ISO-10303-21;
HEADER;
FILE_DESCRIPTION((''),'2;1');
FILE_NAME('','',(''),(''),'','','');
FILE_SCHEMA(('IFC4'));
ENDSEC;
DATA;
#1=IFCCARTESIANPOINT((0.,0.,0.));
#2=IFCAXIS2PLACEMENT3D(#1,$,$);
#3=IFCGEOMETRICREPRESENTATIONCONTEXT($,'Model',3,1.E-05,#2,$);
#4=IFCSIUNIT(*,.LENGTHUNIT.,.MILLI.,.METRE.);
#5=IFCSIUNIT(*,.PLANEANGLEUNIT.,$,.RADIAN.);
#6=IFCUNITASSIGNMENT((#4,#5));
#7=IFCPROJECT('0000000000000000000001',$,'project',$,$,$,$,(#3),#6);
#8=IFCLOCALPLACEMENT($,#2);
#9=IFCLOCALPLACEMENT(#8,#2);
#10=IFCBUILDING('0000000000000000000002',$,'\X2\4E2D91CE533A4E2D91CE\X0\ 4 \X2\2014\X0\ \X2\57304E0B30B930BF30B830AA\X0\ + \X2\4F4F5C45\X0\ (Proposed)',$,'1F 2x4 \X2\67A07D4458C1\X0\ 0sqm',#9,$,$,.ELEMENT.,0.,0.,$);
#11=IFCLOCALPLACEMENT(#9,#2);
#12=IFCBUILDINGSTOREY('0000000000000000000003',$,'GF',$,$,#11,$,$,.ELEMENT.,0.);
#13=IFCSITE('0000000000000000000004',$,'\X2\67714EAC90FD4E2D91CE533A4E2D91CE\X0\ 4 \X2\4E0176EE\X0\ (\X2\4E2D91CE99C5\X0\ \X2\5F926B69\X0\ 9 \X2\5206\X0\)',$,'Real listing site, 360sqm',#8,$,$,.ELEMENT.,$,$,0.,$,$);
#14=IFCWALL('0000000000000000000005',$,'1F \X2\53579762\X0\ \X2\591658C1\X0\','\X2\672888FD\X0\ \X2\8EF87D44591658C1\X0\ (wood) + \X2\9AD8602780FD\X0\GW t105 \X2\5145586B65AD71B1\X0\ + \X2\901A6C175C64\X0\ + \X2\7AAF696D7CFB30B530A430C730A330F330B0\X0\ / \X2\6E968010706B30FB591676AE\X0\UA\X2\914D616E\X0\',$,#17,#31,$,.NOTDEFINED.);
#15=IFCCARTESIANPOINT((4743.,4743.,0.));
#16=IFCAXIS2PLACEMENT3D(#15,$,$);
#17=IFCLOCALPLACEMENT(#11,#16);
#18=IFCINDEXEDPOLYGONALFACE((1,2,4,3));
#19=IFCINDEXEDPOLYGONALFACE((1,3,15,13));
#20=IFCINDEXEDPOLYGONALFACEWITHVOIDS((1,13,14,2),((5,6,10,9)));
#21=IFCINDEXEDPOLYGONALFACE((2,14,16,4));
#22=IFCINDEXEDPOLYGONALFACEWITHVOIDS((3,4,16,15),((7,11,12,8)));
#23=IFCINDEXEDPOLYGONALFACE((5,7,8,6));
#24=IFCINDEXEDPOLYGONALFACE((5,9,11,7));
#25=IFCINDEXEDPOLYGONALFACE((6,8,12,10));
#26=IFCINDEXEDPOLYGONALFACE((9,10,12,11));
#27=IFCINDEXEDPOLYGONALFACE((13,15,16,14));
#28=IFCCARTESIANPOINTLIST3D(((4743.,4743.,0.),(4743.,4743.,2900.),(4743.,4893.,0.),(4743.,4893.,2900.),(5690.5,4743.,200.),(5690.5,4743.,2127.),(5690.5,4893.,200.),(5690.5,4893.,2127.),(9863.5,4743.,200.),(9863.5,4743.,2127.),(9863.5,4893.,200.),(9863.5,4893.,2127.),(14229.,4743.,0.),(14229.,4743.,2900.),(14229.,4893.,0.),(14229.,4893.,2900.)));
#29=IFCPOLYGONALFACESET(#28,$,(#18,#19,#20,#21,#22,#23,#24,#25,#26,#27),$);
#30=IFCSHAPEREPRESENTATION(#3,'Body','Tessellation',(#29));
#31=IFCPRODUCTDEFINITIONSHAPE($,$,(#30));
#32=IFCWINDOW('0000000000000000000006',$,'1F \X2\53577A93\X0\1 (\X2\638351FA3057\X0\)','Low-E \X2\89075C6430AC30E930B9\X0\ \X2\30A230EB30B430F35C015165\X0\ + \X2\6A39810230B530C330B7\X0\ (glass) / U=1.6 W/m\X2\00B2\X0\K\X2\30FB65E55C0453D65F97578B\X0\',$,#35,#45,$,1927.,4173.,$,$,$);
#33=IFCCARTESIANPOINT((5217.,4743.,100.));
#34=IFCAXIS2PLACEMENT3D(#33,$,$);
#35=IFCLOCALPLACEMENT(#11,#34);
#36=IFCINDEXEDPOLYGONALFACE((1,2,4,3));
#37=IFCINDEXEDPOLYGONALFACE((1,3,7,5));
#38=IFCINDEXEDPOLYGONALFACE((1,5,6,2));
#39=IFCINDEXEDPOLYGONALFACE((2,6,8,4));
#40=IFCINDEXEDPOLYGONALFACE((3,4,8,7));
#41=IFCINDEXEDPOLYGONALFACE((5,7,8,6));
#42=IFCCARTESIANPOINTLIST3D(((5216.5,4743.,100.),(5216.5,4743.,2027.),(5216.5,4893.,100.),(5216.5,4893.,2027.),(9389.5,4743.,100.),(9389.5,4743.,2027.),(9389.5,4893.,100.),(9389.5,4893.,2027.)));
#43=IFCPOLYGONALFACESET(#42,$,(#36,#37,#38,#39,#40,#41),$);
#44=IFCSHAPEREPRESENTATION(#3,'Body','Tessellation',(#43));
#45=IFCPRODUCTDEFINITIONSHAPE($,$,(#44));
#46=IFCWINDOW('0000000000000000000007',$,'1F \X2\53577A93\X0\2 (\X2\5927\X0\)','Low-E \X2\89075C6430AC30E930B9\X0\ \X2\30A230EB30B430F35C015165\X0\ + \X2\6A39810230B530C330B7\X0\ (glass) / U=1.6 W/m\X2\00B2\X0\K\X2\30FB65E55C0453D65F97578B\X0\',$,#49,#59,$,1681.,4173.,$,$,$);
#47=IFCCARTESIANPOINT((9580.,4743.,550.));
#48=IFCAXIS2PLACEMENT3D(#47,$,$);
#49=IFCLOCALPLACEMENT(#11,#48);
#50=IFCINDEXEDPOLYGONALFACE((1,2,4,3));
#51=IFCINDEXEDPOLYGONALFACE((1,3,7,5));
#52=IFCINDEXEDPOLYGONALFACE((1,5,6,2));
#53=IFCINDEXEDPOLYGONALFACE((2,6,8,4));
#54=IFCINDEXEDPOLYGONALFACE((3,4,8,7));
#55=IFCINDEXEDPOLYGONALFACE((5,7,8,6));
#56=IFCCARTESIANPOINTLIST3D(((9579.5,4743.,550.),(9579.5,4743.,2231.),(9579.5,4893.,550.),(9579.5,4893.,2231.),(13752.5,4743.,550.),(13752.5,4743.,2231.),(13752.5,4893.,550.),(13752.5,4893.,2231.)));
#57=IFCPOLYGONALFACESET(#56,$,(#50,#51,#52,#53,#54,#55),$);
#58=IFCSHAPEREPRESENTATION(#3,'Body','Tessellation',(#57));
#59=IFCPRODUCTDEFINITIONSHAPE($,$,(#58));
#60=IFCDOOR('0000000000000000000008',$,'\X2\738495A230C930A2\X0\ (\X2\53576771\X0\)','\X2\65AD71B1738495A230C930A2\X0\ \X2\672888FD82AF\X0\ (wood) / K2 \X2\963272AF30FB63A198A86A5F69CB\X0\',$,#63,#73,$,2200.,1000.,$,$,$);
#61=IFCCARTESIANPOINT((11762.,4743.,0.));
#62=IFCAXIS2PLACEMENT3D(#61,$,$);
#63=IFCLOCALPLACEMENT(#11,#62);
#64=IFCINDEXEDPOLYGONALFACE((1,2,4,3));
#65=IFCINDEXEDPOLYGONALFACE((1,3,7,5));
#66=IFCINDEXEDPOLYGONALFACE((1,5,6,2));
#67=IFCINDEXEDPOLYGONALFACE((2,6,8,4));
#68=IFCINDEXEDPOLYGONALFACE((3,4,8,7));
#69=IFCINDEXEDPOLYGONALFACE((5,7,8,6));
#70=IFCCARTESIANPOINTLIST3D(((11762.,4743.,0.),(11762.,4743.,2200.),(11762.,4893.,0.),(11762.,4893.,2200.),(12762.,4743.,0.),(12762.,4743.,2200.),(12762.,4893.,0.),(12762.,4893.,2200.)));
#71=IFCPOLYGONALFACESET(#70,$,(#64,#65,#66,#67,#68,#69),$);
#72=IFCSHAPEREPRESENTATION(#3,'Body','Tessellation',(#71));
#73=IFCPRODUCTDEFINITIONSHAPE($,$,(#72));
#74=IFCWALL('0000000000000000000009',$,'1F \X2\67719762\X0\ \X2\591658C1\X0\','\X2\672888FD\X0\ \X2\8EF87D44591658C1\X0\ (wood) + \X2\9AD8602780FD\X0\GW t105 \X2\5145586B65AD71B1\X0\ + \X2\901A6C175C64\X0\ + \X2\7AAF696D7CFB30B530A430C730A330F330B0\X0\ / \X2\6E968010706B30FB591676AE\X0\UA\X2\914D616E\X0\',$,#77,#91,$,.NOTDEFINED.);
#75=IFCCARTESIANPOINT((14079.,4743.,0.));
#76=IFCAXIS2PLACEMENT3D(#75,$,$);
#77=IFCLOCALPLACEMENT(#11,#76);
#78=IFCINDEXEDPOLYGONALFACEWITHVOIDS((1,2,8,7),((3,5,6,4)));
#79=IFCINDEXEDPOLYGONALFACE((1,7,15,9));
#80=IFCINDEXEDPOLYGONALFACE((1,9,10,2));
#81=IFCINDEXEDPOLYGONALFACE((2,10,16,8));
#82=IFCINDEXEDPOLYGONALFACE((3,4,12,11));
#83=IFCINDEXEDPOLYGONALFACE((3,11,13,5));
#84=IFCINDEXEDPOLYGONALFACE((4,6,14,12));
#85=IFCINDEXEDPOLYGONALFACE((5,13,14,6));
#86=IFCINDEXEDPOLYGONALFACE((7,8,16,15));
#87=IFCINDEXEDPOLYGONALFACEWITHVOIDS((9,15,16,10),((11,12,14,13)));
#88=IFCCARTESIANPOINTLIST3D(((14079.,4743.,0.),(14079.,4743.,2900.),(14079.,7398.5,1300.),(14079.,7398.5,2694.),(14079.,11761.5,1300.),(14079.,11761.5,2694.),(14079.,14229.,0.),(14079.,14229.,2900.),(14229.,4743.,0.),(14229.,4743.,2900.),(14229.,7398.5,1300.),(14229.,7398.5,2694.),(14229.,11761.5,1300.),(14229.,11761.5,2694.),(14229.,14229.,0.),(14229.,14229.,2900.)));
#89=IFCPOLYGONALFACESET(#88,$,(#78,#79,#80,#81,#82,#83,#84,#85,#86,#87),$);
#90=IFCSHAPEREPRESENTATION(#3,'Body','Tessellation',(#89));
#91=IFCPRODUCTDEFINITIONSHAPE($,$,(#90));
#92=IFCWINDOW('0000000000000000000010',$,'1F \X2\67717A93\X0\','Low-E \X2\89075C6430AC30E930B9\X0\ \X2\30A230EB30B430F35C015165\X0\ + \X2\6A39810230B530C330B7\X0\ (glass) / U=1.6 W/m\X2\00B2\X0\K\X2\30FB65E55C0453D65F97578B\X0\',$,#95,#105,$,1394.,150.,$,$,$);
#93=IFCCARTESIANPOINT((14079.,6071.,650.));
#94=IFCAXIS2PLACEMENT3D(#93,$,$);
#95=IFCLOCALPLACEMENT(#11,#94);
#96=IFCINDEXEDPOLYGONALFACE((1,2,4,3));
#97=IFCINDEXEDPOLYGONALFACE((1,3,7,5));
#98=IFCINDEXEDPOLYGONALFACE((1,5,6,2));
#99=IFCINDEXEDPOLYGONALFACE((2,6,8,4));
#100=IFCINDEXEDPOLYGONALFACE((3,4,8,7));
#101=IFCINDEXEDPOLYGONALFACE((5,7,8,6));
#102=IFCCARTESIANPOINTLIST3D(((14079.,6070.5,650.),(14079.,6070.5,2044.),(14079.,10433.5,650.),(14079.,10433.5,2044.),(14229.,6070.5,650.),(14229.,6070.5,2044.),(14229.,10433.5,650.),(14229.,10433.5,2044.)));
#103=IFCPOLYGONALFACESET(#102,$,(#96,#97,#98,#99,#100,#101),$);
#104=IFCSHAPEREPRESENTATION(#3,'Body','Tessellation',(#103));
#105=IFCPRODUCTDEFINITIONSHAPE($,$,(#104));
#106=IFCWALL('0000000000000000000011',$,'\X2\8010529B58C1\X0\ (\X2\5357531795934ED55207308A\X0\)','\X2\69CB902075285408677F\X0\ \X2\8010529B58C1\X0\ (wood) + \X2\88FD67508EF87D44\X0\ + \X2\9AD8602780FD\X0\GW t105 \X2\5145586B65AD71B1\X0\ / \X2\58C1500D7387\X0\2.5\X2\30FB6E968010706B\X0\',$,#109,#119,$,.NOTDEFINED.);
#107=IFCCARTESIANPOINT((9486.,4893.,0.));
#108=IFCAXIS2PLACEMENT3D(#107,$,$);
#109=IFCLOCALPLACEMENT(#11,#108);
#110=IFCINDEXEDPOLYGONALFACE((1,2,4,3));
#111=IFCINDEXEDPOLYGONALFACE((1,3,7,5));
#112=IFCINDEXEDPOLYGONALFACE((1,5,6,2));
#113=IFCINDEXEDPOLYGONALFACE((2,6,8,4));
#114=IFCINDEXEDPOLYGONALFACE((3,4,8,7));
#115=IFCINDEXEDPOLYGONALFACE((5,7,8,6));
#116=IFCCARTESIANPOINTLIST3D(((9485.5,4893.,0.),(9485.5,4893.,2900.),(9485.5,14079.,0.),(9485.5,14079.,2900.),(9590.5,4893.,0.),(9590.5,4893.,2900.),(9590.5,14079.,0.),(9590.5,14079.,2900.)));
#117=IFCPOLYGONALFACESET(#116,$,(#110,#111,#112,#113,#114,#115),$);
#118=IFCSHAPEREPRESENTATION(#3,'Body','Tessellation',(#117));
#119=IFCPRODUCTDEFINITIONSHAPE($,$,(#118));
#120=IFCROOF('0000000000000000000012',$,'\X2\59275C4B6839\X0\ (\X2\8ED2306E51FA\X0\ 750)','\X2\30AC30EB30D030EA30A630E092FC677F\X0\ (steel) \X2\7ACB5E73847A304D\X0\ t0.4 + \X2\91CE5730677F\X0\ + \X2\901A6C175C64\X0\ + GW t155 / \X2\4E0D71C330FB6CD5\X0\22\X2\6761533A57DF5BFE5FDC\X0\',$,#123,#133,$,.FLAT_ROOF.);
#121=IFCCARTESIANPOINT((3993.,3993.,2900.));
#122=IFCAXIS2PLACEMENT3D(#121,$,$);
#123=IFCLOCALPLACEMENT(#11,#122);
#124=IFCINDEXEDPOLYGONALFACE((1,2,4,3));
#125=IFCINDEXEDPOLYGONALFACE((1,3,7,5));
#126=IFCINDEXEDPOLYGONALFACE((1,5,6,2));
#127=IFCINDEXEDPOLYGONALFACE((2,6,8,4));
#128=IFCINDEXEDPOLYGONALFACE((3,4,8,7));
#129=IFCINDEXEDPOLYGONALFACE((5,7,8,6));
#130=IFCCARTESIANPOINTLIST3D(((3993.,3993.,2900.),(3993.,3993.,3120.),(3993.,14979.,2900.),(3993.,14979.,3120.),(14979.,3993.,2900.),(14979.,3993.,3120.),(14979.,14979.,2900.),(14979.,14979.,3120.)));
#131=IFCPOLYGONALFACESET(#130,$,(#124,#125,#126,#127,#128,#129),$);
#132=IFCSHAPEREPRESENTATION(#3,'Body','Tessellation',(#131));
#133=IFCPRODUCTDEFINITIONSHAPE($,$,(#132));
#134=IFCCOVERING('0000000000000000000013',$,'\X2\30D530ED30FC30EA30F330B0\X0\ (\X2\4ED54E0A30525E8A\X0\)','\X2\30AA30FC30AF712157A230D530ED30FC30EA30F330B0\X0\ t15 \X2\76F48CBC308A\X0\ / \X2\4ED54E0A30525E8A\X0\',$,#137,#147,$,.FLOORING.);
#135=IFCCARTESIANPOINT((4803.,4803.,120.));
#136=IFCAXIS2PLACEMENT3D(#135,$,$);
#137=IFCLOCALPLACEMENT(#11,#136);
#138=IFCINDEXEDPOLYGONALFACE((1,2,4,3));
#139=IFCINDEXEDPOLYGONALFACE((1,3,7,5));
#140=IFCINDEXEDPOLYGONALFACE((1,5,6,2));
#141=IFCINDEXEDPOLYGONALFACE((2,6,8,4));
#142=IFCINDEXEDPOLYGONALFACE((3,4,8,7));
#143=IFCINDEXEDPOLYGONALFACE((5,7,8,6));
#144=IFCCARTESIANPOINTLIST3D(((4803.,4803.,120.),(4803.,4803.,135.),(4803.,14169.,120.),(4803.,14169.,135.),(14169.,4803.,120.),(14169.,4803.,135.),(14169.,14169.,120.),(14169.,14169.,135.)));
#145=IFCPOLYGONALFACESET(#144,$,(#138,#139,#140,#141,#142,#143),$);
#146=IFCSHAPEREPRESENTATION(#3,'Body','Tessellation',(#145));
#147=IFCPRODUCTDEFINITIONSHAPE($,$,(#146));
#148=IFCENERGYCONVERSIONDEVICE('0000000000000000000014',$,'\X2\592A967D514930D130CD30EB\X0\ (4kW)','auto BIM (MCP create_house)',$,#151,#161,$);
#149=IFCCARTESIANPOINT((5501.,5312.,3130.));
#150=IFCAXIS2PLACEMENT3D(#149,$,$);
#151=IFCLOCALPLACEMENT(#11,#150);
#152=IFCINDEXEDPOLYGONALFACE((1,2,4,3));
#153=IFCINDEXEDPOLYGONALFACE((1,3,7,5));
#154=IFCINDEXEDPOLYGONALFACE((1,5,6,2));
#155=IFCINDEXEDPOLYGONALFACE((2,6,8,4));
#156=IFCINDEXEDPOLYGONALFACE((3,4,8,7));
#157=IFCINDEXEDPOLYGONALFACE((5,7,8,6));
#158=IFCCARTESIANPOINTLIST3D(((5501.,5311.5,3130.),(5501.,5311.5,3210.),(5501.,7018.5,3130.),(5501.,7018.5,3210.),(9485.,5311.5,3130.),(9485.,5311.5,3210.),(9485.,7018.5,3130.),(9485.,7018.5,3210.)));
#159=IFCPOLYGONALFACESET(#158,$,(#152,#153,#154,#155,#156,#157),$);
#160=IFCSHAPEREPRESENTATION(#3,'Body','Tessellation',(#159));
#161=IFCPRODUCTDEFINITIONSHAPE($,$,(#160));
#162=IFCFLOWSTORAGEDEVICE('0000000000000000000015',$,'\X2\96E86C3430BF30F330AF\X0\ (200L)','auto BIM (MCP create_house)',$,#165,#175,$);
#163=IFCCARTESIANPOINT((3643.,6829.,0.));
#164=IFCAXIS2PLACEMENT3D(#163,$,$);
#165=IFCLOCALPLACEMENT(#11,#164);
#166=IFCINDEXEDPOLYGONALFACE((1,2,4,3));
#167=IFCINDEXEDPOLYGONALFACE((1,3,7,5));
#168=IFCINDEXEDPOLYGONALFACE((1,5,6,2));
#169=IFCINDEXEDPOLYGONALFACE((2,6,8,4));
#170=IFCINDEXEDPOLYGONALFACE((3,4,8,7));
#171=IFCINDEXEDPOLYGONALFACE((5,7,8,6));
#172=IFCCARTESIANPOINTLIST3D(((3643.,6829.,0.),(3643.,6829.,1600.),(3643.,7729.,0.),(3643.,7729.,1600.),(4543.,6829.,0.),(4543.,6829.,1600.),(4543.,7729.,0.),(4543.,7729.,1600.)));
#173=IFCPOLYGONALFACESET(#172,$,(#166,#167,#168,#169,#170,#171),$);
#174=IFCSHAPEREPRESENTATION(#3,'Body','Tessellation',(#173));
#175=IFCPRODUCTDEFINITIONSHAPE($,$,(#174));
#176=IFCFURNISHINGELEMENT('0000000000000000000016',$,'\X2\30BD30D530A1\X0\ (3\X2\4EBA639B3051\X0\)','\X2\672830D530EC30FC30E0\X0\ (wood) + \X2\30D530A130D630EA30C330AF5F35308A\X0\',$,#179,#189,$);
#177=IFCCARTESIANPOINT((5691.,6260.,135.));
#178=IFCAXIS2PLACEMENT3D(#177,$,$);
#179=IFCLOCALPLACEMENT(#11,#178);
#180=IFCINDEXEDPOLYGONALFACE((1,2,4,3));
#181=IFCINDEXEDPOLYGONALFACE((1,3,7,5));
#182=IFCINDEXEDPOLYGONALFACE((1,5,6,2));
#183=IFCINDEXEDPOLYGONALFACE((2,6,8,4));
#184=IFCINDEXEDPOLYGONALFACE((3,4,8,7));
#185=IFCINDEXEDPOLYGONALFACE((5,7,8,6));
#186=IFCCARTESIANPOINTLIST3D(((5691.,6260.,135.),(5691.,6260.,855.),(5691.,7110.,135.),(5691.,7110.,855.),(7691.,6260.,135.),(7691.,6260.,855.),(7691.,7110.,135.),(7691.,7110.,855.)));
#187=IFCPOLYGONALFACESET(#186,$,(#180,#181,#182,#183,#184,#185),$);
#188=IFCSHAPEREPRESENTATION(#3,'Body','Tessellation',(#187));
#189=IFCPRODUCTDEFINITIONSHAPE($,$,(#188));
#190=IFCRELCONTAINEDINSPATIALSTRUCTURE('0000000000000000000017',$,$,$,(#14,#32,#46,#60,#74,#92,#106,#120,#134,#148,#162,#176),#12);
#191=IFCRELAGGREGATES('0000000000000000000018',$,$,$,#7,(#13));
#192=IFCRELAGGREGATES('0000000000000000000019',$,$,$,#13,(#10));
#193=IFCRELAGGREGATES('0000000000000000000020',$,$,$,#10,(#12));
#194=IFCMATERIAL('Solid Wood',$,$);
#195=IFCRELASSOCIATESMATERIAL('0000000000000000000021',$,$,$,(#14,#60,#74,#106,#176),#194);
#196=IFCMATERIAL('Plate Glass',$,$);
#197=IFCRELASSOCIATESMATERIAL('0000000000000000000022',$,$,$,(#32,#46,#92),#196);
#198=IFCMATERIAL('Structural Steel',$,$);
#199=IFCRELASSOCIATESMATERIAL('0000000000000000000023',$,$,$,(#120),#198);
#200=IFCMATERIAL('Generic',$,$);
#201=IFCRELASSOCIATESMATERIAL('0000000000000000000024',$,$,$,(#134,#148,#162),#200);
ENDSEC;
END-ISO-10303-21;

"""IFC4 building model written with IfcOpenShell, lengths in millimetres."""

from ifc_helpers import new_model, si_unit, frame, frame_2d, origin, place, context, project, spatial, rectangle, extrude, material, element, fill, save


model = new_model("IFC4")

# Units and contexts
model_context = context("Model", 3, precision=1e-05, world=origin())
ifc_project = project(units=[si_unit("LENGTHUNIT", "METRE", prefix="MILLI"), si_unit("PLANEANGLEUNIT", "RADIAN")], contexts=[model_context])

# Site, building, storey
site_placement = place(None, origin())
site = spatial("IfcSite", under=ifc_project, at=site_placement, Name="東京都中野区中野 4 丁目 (中野駅 徒歩 9 分)", ObjectType="Real listing site, 360sqm", CompositionType="ELEMENT", RefElevation=0.0)
building_placement = place(site_placement, origin())
building = spatial("IfcBuilding", under=site, at=building_placement, Name="中野区中野 4 — 地下スタジオ + 住居 (Proposed)", ObjectType="1F 2x4 枠組壁 0sqm", CompositionType="ELEMENT", ElevationOfRefHeight=0.0, ElevationOfTerrain=0.0)
storey_placement = place(building_placement, origin())
storey = spatial("IfcBuildingStorey", under=building, at=storey_placement, Name="GF", CompositionType="ELEMENT", Elevation=0.0)

# Shared definitions
ifc_material_1 = material(Name="Solid Wood")

# Wall, openings, windows, door
wall_1_placement = place(storey_placement, frame((4743.0, 4743.0, 0.0)))
wall_1 = element("IfcWall", 1, at=wall_1_placement, inside=storey, material=ifc_material_1, Name="1F 南面 外壁", Description="木製 軸組外壁 (wood) + 高性能GW t105 充填断熱 + 通気層 + 窯業系サイディング / 準耐火・外皮UA配慮", PredefinedType="NOTDEFINED", context=model_context, shape_type="SweptSolid", body=[
    extrude(rectangle(XDim=9486.0, YDim=150.0, at=frame_2d((4743.0, 75.0))), frame((4743.0, 4743.0, 0.0)), (0.0, 0.0, 1.0), 2900.0),
])
opening_1_placement = place(storey_placement, frame((5217.0, 4743.0, 100.0)))
opening_1 = element("IfcOpeningElement", 2, at=opening_1_placement, cuts=wall_1, PredefinedType="NOTDEFINED", context=model_context, shape_type="SweptSolid", body=[
    extrude(rectangle(XDim=4173.0, YDim=150.0, at=frame_2d((2086.0, 75.0))), frame((5217.0, 4743.0, 100.0)), (0.0, 0.0, 1.0), 1927.0),
])
opening_2_placement = place(storey_placement, frame((9580.0, 4743.0, 550.0)))
opening_2 = element("IfcOpeningElement", 3, at=opening_2_placement, cuts=wall_1, PredefinedType="NOTDEFINED", context=model_context, shape_type="SweptSolid", body=[
    extrude(rectangle(XDim=4173.0, YDim=150.0, at=frame_2d((2086.0, 75.0))), frame((9580.0, 4743.0, 550.0)), (0.0, 0.0, 1.0), 1681.0),
])
opening_3_placement = place(storey_placement, frame((11762.0, 4743.0, 0.0)))
opening_3 = element("IfcOpeningElement", 4, at=opening_3_placement, cuts=wall_1, PredefinedType="NOTDEFINED", context=model_context, shape_type="SweptSolid", body=[
    extrude(rectangle(XDim=1000.0, YDim=150.0, at=frame_2d((500.0, 75.0))), frame((11762.0, 4743.0, 0.0)), (0.0, 0.0, 1.0), 2200.0),
])
ifc_material_2 = material(Name="Plate Glass")
window_1_placement = place(storey_placement, frame((5217.0, 4743.0, 100.0)))
window_1 = element("IfcWindow", 5, at=window_1_placement, inside=storey, material=ifc_material_2, Name="1F 南窓1 (掃出し)", Description="Low-E 複層ガラス アルゴン封入 + 樹脂サッシ (glass) / U=1.6 W/m²K・日射取得型", OverallHeight=1927.0, OverallWidth=4173.0, context=model_context, shape_type="SweptSolid", body=[
    extrude(rectangle(XDim=4173.0, YDim=150.0, at=frame_2d((2086.0, 75.0))), frame((5217.0, 4743.0, 100.0)), (0.0, 0.0, 1.0), 1927.0),
])
fill(opening_1, window_1)
window_2_placement = place(storey_placement, frame((9580.0, 4743.0, 550.0)))
window_2 = element("IfcWindow", 6, at=window_2_placement, inside=storey, material=ifc_material_2, Name="1F 南窓2 (大)", Description="Low-E 複層ガラス アルゴン封入 + 樹脂サッシ (glass) / U=1.6 W/m²K・日射取得型", OverallHeight=1681.0, OverallWidth=4173.0, context=model_context, shape_type="SweptSolid", body=[
    extrude(rectangle(XDim=4173.0, YDim=150.0, at=frame_2d((2086.0, 75.0))), frame((9580.0, 4743.0, 550.0)), (0.0, 0.0, 1.0), 1681.0),
])
fill(opening_2, window_2)
door_placement = place(storey_placement, frame((11762.0, 4743.0, 0.0)))
door = element("IfcDoor", 7, at=door_placement, inside=storey, material=ifc_material_1, Name="玄関ドア (南東)", Description="断熱玄関ドア 木製芯 (wood) / K2 防犯・採風機構", OverallHeight=2200.0, OverallWidth=1000.0, context=model_context, shape_type="SweptSolid", body=[
    extrude(rectangle(XDim=1000.0, YDim=150.0, at=frame_2d((500.0, 75.0))), frame((11762.0, 4743.0, 0.0)), (0.0, 0.0, 1.0), 2200.0),
])
fill(opening_3, door)

# Wall, opening, window
wall_2_placement = place(storey_placement, frame((14079.0, 4743.0, 0.0)))
wall_2 = element("IfcWall", 8, at=wall_2_placement, inside=storey, material=ifc_material_1, Name="1F 東面 外壁", Description="木製 軸組外壁 (wood) + 高性能GW t105 充填断熱 + 通気層 + 窯業系サイディング / 準耐火・外皮UA配慮", PredefinedType="NOTDEFINED", context=model_context, shape_type="SweptSolid", body=[
    extrude(rectangle(XDim=150.0, YDim=9486.0, at=frame_2d((75.0, 4743.0))), frame((14079.0, 4743.0, 0.0)), (0.0, 0.0, 1.0), 2900.0),
])
opening_4_placement = place(storey_placement, frame((14079.0, 6071.0, 650.0)))
opening_4 = element("IfcOpeningElement", 9, at=opening_4_placement, cuts=wall_2, PredefinedType="NOTDEFINED", context=model_context, shape_type="SweptSolid", body=[
    extrude(rectangle(XDim=150.0, YDim=4363.0, at=frame_2d((75.0, 2181.0))), frame((14079.0, 6071.0, 650.0)), (0.0, 0.0, 1.0), 1394.0),
])
window_3_placement = place(storey_placement, frame((14079.0, 6071.0, 650.0)))
window_3 = element("IfcWindow", 10, at=window_3_placement, inside=storey, material=ifc_material_2, Name="1F 東窓", Description="Low-E 複層ガラス アルゴン封入 + 樹脂サッシ (glass) / U=1.6 W/m²K・日射取得型", OverallHeight=1394.0, OverallWidth=150.0, context=model_context, shape_type="SweptSolid", body=[
    extrude(rectangle(XDim=150.0, YDim=4363.0, at=frame_2d((75.0, 2181.0))), frame((14079.0, 6071.0, 650.0)), (0.0, 0.0, 1.0), 1394.0),
])
fill(opening_4, window_3)

# Wall
wall_3_placement = place(storey_placement, frame((9486.0, 4893.0, 0.0)))
element("IfcWall", 11, at=wall_3_placement, inside=storey, material=ifc_material_1, Name="耐力壁 (南北間仕切り)", Description="構造用合板 耐力壁 (wood) + 製材軸組 + 高性能GW t105 充填断熱 / 壁倍率2.5・準耐火", PredefinedType="NOTDEFINED", context=model_context, shape_type="SweptSolid", body=[
    extrude(rectangle(XDim=105.0, YDim=9186.0, at=frame_2d((52.0, 4593.0))), frame((9486.0, 4893.0, 0.0)), (0.0, 0.0, 1.0), 2900.0),
])

# Roof
ifc_material_3 = material(Name="Structural Steel")
roof_placement = place(storey_placement, frame((3993.0, 3993.0, 2900.0)))
element("IfcRoof", 12, at=roof_placement, inside=storey, material=ifc_material_3, Name="大屋根 (軒の出 750)", Description="ガルバリウム鋼板 (steel) 立平葺き t0.4 + 野地板 + 通気層 + GW t155 / 不燃・法22条区域対応", PredefinedType="FLAT_ROOF", context=model_context, shape_type="SweptSolid", body=[
    extrude(rectangle(XDim=10986.0, YDim=10986.0, at=frame_2d((5493.0, 5493.0))), frame((3993.0, 3993.0, 2900.0)), (0.0, 0.0, 1.0), 220.0),
])

# Covering
ifc_material_4 = material(Name="Generic")
covering_placement = place(storey_placement, frame((4803.0, 4803.0, 120.0)))
element("IfcCovering", 13, at=covering_placement, inside=storey, material=ifc_material_4, Name="フローリング (仕上げ床)", Description="オーク無垢フローリング t15 直貼り / 仕上げ床", PredefinedType="FLOORING", context=model_context, shape_type="SweptSolid", body=[
    extrude(rectangle(XDim=9366.0, YDim=9366.0, at=frame_2d((4683.0, 4683.0))), frame((4803.0, 4803.0, 120.0)), (0.0, 0.0, 1.0), 15.0),
])

# Energy conversion device
energy_conversion_device_placement = place(storey_placement, frame((5501.0, 5312.0, 3130.0)))
element("IfcEnergyConversionDevice", 14, at=energy_conversion_device_placement, inside=storey, material=ifc_material_4, Name="太陽光パネル (4kW)", Description="auto BIM (MCP create_house)", context=model_context, shape_type="SweptSolid", body=[
    extrude(rectangle(XDim=3984.0, YDim=1707.0, at=frame_2d((1992.0, 853.0))), frame((5501.0, 5312.0, 3130.0)), (0.0, 0.0, 1.0), 80.0),
])

# Flow storage device
flow_storage_device_placement = place(storey_placement, frame((3643.0, 6829.0, 0.0)))
element("IfcFlowStorageDevice", 15, at=flow_storage_device_placement, inside=storey, material=ifc_material_4, Name="雨水タンク (200L)", Description="auto BIM (MCP create_house)", context=model_context, shape_type="SweptSolid", body=[
    extrude(rectangle(XDim=900.0, YDim=900.0, at=frame_2d((450.0, 450.0))), frame((3643.0, 6829.0, 0.0)), (0.0, 0.0, 1.0), 1600.0),
])

# Furnishing element
furnishing_1_placement = place(storey_placement, frame((5691.0, 6260.0, 135.0)))
element("IfcFurnishingElement", 16, at=furnishing_1_placement, inside=storey, material=ifc_material_1, Name="ソファ (3人掛け)", Description="木フレーム (wood) + ファブリック張り", context=model_context, shape_type="SweptSolid", body=[
    extrude(rectangle(XDim=2000.0, YDim=850.0, at=frame_2d((1000.0, 425.0))), frame((5691.0, 6260.0, 135.0)), (0.0, 0.0, 1.0), 720.0),
])

save(model, "model.ifc")
